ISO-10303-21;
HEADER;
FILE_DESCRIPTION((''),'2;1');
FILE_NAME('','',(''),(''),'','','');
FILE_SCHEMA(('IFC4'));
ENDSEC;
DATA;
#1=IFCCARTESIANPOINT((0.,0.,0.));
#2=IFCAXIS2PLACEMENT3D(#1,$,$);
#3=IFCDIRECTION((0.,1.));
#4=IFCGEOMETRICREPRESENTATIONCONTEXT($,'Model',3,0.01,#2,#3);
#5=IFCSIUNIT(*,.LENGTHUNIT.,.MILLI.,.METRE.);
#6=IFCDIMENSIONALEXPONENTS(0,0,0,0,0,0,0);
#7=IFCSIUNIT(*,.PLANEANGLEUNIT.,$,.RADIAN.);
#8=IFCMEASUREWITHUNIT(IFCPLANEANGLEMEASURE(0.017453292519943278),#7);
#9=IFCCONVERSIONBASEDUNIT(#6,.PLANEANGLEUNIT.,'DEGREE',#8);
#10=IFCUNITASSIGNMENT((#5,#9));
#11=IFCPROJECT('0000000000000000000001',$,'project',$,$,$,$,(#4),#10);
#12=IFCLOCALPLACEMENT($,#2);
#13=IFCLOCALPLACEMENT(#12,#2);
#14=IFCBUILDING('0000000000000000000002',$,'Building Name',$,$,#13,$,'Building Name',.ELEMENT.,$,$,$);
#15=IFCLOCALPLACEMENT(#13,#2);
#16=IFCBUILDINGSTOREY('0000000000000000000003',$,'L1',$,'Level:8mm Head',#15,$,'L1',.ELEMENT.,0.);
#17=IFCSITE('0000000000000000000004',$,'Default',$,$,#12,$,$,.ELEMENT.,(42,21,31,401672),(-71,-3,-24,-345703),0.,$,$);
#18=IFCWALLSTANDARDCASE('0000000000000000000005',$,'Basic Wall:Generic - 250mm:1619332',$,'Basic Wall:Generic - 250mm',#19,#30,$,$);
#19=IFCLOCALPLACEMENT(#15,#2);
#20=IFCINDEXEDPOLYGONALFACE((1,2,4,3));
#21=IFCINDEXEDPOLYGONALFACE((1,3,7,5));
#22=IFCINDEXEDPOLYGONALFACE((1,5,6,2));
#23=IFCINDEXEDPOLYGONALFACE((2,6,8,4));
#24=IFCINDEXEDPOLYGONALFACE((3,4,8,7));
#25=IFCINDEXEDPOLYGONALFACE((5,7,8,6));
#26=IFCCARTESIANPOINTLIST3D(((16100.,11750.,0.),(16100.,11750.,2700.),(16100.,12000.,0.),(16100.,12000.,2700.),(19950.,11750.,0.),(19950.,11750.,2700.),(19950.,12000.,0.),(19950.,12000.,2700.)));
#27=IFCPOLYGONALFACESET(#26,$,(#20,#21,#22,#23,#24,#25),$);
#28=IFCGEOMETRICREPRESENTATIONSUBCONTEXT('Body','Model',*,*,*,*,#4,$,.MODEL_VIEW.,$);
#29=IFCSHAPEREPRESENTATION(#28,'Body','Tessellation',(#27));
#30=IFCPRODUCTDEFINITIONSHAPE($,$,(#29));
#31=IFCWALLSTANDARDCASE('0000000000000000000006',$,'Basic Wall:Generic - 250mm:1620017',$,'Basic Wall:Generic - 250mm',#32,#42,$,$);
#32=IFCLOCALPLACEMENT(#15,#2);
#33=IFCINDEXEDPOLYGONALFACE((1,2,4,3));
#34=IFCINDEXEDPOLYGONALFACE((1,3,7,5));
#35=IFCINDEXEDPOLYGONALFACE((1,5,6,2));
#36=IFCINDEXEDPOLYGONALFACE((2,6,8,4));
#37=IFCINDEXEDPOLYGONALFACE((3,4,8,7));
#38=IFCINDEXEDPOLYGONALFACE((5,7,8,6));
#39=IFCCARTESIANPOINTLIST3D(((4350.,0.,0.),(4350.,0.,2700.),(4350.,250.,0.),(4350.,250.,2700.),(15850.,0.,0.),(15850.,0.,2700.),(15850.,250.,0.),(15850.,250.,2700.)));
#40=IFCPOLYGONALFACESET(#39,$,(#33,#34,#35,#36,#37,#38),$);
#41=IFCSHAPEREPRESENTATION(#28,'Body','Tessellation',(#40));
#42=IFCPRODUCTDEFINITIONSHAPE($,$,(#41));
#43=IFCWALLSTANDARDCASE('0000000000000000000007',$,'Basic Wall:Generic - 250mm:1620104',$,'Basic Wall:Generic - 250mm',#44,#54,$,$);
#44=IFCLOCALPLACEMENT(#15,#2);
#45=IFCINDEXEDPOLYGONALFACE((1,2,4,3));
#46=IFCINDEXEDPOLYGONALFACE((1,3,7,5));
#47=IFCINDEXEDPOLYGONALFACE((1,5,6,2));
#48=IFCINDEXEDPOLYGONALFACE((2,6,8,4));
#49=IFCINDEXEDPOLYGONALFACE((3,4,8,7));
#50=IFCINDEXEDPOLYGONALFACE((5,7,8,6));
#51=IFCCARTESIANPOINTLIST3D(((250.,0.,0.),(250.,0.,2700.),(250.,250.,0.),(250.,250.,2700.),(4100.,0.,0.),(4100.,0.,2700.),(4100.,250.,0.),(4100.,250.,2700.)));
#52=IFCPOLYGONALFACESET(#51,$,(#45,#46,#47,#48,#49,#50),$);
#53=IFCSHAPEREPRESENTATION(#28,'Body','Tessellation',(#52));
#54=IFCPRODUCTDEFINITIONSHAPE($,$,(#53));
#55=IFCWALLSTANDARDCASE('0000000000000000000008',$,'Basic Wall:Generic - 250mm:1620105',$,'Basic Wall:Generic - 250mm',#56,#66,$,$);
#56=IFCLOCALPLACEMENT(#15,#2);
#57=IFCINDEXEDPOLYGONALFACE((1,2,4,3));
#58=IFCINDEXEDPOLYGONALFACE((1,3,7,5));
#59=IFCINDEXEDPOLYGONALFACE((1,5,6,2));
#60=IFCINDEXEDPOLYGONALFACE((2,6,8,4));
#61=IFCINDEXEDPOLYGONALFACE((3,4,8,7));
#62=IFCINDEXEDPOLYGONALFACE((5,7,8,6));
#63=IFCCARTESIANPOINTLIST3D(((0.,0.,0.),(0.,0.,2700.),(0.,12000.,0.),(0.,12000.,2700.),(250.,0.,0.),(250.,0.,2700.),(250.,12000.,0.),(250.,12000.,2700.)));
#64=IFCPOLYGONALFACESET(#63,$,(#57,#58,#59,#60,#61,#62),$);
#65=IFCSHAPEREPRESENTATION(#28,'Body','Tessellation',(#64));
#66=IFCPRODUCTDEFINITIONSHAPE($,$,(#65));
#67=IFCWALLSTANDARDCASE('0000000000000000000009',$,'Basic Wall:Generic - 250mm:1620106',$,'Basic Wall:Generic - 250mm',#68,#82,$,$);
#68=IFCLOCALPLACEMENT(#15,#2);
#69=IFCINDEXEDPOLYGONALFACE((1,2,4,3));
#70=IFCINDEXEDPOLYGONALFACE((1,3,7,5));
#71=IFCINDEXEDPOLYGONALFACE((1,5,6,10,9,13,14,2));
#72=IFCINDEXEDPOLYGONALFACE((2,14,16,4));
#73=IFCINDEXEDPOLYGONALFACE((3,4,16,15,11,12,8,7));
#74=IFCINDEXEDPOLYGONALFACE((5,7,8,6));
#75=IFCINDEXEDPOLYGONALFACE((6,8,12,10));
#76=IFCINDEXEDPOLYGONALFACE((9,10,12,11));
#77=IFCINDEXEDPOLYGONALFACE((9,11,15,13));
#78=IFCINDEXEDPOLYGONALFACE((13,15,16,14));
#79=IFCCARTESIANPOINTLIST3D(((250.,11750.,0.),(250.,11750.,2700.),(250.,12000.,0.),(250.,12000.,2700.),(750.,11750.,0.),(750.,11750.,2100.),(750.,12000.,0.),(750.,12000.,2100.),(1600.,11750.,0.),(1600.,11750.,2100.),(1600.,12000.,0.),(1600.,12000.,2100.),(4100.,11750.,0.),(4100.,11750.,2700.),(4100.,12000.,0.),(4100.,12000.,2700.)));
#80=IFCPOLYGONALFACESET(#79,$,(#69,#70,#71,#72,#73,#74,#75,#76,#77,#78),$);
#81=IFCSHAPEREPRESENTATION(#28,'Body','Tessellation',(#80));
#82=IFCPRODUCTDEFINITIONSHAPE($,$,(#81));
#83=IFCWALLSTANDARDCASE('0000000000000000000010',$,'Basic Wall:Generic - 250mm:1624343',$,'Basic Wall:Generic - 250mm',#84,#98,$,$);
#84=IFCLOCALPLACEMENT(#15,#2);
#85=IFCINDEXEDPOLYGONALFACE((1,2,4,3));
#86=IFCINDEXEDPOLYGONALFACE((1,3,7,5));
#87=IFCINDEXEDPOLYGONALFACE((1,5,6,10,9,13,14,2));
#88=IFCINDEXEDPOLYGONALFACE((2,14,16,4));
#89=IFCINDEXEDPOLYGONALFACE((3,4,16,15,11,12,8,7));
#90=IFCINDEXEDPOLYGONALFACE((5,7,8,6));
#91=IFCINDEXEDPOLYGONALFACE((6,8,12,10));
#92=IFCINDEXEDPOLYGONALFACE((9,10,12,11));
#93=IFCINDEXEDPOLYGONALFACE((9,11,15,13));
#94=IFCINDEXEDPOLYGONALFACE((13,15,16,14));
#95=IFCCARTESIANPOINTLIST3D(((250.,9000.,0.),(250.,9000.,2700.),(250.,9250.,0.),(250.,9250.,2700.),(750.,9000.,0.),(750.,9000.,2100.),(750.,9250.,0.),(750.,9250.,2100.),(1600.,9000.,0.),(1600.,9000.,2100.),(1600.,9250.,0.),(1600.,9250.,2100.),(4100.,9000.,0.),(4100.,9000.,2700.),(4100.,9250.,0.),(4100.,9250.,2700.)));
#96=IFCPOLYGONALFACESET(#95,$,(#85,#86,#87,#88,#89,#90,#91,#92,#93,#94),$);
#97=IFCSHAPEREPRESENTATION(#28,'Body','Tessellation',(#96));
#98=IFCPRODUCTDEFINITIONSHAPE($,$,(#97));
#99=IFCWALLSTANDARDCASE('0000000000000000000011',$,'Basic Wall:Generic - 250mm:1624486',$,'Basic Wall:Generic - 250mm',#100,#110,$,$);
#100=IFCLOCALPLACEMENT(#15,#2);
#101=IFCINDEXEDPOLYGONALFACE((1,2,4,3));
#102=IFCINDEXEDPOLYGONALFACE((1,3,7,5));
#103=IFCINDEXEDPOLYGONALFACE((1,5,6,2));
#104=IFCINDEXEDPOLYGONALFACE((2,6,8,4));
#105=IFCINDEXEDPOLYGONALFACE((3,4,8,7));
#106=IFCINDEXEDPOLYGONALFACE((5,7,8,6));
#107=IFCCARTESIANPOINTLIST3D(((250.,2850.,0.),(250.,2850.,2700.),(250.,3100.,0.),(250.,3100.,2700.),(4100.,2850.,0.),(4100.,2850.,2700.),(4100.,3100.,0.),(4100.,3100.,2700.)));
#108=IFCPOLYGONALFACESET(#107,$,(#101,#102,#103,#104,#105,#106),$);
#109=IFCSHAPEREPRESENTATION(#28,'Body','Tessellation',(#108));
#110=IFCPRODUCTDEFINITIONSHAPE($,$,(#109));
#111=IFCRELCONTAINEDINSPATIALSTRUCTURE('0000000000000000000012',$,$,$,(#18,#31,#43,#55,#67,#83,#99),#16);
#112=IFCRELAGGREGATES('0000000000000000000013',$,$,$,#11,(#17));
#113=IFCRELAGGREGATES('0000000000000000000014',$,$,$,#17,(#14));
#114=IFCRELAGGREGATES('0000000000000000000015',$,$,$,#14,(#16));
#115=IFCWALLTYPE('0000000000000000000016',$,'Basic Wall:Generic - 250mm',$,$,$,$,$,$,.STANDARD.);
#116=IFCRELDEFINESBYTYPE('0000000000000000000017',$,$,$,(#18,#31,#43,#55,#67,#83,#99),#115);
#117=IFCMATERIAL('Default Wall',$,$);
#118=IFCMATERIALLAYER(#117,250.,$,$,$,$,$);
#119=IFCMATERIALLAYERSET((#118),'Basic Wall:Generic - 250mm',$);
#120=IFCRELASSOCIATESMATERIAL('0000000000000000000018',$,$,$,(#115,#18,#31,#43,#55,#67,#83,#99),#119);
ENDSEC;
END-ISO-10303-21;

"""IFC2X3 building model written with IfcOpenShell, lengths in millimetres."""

from ifc_helpers import new_model, entity, si_unit, converted_unit, direction, frame, frame_2d, origin, place, context, subcontext, project, spatial, rectangle, extrude, material, layer, layer_set, layer_usage, type_object, element, save


model = new_model("IFC2X3")

# Units and contexts
model_context = context("Model", 3, precision=0.01, world=origin(), true_north=direction((0.0, 1.0)))
body_context = subcontext(model_context, "Body", "Model", "MODEL_VIEW")
ifc_project = project(units=[si_unit("LENGTHUNIT", "METRE", prefix="MILLI"), converted_unit("PLANEANGLEUNIT", "DEGREE", entity("IfcPlaneAngleMeasure", 0.017453292519943278), si_unit("PLANEANGLEUNIT", "RADIAN"), dimensions=[0, 0, 0, 0, 0, 0, 0])], contexts=[model_context])

# Site, building, storey
site_placement = place(None, origin())
site = spatial("IfcSite", under=ifc_project, at=site_placement, Name="Default", CompositionType="ELEMENT", RefLatitude=(42, 21, 31, 401672), RefLongitude=(-71, -3, -24, -345703), RefElevation=0.0)
building_placement = place(site_placement, origin())
building = spatial("IfcBuilding", under=site, at=building_placement, Name="Building Name", LongName="Building Name", CompositionType="ELEMENT")
storey_placement = place(building_placement, origin())
storey = spatial("IfcBuildingStorey", under=building, at=storey_placement, Name="L1", ObjectType="Level:8mm Head", LongName="L1", CompositionType="ELEMENT", Elevation=0.0)

# Shared definitions
ifc_material_1 = material(Name="Default Wall")
ifc_layer_1 = layer(ifc_material_1, 250.0)
ifc_layer_set_1 = layer_set([ifc_layer_1], Name="Basic Wall:Generic - 250mm")
wall_type = type_object("IfcWallType", Name="Basic Wall:Generic - 250mm", PredefinedType="STANDARD", material=ifc_layer_set_1)

# Walls
ifc_layer_usage_1 = layer_usage(ifc_layer_set_1, "AXIS2", "NEGATIVE", 125.0)
wall_1_placement = place(storey_placement, frame((19950.0, 11875.0, 0.0), z_axis=(0.0, 0.0, 1.0), x_axis=(-1.0, 0.0, 0.0)))
element("IfcWallStandardCase", 1, at=wall_1_placement, inside=storey, type_object=wall_type, material=ifc_layer_usage_1, Name="Basic Wall:Generic - 250mm:1619332", ObjectType="Basic Wall:Generic - 250mm", context=body_context, shape_type="SweptSolid", body=[
    extrude(rectangle(XDim=3850.0, YDim=250.0, at=frame_2d((1925.0, 0.0), x_axis=(-1.0, 0.0))), origin(), (0.0, 0.0, 1.0), 2700.0),
])
ifc_layer_usage_2 = layer_usage(ifc_layer_set_1, "AXIS2", "NEGATIVE", 125.0)
wall_2_placement = place(storey_placement, frame((4350.0, 125.0, 0.0)))
element("IfcWallStandardCase", 2, at=wall_2_placement, inside=storey, type_object=wall_type, material=ifc_layer_usage_2, Name="Basic Wall:Generic - 250mm:1620017", ObjectType="Basic Wall:Generic - 250mm", context=body_context, shape_type="SweptSolid", body=[
    extrude(rectangle(XDim=11500.0, YDim=250.0, at=frame_2d((5750.0, 0.0), x_axis=(-1.0, 0.0))), origin(), (0.0, 0.0, 1.0), 2700.0),
])
ifc_layer_usage_3 = layer_usage(ifc_layer_set_1, "AXIS2", "POSITIVE", -125.0)
wall_3_placement = place(storey_placement, frame((4100.0, 125.0, 0.0), z_axis=(0.0, 0.0, 1.0), x_axis=(-1.0, 0.0, 0.0)))
element("IfcWallStandardCase", 3, at=wall_3_placement, inside=storey, type_object=wall_type, material=ifc_layer_usage_3, Name="Basic Wall:Generic - 250mm:1620104", ObjectType="Basic Wall:Generic - 250mm", context=body_context, shape_type="SweptSolid", body=[
    extrude(rectangle(XDim=3850.0, YDim=250.0, at=frame_2d((1925.0, 0.0), x_axis=(-1.0, 0.0))), origin(), (0.0, 0.0, 1.0), 2700.0),
])
ifc_layer_usage_4 = layer_usage(ifc_layer_set_1, "AXIS2", "POSITIVE", -125.0)
wall_4_placement = place(storey_placement, frame((125.0, 0.0, 0.0), z_axis=(0.0, 0.0, 1.0), x_axis=(0.0, 1.0, 0.0)))
element("IfcWallStandardCase", 4, at=wall_4_placement, inside=storey, type_object=wall_type, material=ifc_layer_usage_4, Name="Basic Wall:Generic - 250mm:1620105", ObjectType="Basic Wall:Generic - 250mm", context=body_context, shape_type="SweptSolid", body=[
    extrude(rectangle(XDim=12000.0, YDim=250.0, at=frame_2d((6000.0, 0.0), x_axis=(-1.0, 0.0))), origin(), (0.0, 0.0, 1.0), 2700.0),
])

# Walls, openings
ifc_layer_usage_5 = layer_usage(ifc_layer_set_1, "AXIS2", "POSITIVE", -125.0)
wall_5_placement = place(storey_placement, frame((250.0, 11875.0, 0.0)))
wall_5 = element("IfcWallStandardCase", 5, at=wall_5_placement, inside=storey, type_object=wall_type, material=ifc_layer_usage_5, Name="Basic Wall:Generic - 250mm:1620106", ObjectType="Basic Wall:Generic - 250mm", context=body_context, shape_type="SweptSolid", body=[
    extrude(rectangle(XDim=3850.0, YDim=250.0, at=frame_2d((1925.0, 0.0), x_axis=(-1.0, 0.0))), origin(), (0.0, 0.0, 1.0), 2700.0),
])
opening_1_placement = place(wall_5_placement, frame((1350.0, 125.0, 0.0)))
element("IfcOpeningElement", 6, at=opening_1_placement, cuts=wall_5, ObjectType="Opening", context=body_context, shape_type="SweptSolid", body=[
    extrude(rectangle(XDim=2100.0, YDim=850.0, at=frame_2d((1050.0, 425.0), x_axis=(1.0, 0.0))), frame((0.0, 0.0, 0.0), z_axis=(0.0, -1.0, 0.0), x_axis=(0.0, 0.0, 1.0)), (0.0, 0.0, 1.0), 250.0),
])
ifc_layer_usage_6 = layer_usage(ifc_layer_set_1, "AXIS2", "NEGATIVE", 125.0)
wall_6_placement = place(storey_placement, frame((250.0, 9125.0, 0.0)))
wall_6 = element("IfcWallStandardCase", 7, at=wall_6_placement, inside=storey, type_object=wall_type, material=ifc_layer_usage_6, Name="Basic Wall:Generic - 250mm:1624343", ObjectType="Basic Wall:Generic - 250mm", context=body_context, shape_type="SweptSolid", body=[
    extrude(rectangle(XDim=3850.0, YDim=250.0, at=frame_2d((1925.0, 0.0), x_axis=(-1.0, 0.0))), origin(), (0.0, 0.0, 1.0), 2700.0),
])
opening_2_placement = place(wall_6_placement, frame((1350.0, 125.0, 0.0)))
element("IfcOpeningElement", 8, at=opening_2_placement, cuts=wall_6, ObjectType="Opening", context=body_context, shape_type="SweptSolid", body=[
    extrude(rectangle(XDim=2100.0, YDim=850.0, at=frame_2d((1050.0, 425.0), x_axis=(1.0, 0.0))), frame((0.0, 0.0, 0.0), z_axis=(0.0, -1.0, 0.0), x_axis=(0.0, 0.0, 1.0)), (0.0, 0.0, 1.0), 250.0),
])

# Wall
ifc_layer_usage_7 = layer_usage(ifc_layer_set_1, "AXIS2", "POSITIVE", -125.0)
wall_7_placement = place(storey_placement, frame((4100.0, 2975.0, 0.0), z_axis=(0.0, 0.0, 1.0), x_axis=(-1.0, 0.0, 0.0)))
element("IfcWallStandardCase", 9, at=wall_7_placement, inside=storey, type_object=wall_type, material=ifc_layer_usage_7, Name="Basic Wall:Generic - 250mm:1624486", ObjectType="Basic Wall:Generic - 250mm", context=body_context, shape_type="SweptSolid", body=[
    extrude(rectangle(XDim=3850.0, YDim=250.0, at=frame_2d((1925.0, 0.0), x_axis=(-1.0, 0.0))), origin(), (0.0, 0.0, 1.0), 2700.0),
])

save(model, "model.ifc")
